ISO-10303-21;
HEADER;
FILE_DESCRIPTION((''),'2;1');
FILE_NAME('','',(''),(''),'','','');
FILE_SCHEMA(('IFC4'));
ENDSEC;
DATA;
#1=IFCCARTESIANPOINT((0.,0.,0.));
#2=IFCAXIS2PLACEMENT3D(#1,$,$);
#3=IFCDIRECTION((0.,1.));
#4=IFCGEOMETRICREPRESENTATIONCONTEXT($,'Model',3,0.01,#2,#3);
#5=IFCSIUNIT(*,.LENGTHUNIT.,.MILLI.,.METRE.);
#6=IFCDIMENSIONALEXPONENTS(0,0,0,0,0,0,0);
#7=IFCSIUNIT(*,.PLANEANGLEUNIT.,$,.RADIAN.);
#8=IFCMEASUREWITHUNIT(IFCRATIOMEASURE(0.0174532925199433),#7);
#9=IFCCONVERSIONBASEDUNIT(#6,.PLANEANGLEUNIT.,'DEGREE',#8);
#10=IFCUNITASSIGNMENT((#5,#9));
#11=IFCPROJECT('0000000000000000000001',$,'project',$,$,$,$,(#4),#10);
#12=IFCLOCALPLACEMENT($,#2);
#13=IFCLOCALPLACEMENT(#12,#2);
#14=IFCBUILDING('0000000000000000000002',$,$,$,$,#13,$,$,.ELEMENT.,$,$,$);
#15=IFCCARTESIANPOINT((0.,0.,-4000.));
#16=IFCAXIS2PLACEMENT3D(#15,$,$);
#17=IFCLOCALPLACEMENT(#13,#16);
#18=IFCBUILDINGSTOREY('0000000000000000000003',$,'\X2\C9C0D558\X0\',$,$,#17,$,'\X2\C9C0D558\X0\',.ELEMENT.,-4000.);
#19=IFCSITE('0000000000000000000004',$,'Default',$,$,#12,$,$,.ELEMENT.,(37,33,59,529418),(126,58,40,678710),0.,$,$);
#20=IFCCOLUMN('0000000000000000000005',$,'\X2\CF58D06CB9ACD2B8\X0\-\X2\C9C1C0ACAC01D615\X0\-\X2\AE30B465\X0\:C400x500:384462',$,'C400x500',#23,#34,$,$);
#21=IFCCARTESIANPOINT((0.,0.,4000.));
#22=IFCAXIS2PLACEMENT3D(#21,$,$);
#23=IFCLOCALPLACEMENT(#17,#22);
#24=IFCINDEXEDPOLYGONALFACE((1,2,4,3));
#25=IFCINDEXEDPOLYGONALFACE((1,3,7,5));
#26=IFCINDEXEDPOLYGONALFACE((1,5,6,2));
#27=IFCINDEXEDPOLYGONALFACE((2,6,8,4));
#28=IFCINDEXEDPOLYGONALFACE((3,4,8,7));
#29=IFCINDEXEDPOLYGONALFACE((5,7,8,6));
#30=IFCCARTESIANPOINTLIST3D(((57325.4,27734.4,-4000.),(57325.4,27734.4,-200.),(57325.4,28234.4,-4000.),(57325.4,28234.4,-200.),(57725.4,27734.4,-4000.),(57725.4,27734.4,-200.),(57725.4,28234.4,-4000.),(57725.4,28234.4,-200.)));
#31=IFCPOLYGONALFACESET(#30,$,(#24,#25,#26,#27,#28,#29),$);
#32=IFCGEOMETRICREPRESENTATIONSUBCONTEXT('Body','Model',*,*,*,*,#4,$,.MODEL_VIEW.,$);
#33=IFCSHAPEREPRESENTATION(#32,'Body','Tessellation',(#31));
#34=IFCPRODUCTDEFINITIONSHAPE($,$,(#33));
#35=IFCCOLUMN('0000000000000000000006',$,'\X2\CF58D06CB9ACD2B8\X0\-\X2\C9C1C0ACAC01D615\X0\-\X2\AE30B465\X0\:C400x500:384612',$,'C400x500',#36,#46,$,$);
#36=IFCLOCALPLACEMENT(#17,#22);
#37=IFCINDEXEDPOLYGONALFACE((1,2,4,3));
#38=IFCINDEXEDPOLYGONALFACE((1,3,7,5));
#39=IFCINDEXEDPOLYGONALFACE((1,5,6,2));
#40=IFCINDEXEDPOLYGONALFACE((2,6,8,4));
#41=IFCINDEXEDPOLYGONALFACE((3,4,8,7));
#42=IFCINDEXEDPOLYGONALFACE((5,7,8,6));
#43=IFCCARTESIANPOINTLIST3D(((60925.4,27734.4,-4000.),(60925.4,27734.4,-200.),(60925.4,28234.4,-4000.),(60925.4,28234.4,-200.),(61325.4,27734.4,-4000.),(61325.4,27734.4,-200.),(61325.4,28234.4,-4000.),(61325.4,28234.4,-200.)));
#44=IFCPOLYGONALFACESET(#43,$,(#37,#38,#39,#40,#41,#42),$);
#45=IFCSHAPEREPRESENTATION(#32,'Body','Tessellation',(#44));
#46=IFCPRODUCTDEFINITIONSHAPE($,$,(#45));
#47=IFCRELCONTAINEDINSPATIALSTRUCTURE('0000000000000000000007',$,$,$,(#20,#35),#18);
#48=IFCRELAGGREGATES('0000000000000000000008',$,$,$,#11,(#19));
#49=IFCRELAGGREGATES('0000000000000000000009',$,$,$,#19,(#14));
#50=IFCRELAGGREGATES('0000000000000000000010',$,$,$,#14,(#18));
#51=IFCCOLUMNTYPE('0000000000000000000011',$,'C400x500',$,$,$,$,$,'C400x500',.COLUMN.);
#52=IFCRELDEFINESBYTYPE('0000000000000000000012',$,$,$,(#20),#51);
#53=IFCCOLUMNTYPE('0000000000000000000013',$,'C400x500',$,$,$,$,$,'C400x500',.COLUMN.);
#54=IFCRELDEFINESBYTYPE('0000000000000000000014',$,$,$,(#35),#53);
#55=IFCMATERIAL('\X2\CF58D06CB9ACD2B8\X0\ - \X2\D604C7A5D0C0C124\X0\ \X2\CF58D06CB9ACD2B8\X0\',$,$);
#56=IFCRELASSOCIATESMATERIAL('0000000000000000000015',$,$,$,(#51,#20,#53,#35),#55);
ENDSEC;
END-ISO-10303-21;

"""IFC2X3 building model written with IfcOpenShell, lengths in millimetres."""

from ifc_helpers import new_model, entity, si_unit, converted_unit, direction, frame, origin, origin_2d_with_axis, place, context, subcontext, project, spatial, rectangle, extrude, source, transform, mapped, material, type_object, type_shapes, element, save


model = new_model("IFC2X3")

# Units and contexts
model_context = context("Model", 3, precision=0.01, world=origin(), true_north=direction((0.0, 1.0)))
body_context = subcontext(model_context, "Body", "Model", "MODEL_VIEW")
ifc_project = project(units=[si_unit("LENGTHUNIT", "METRE", prefix="MILLI"), converted_unit("PLANEANGLEUNIT", "DEGREE", entity("IfcRatioMeasure", 0.0174532925199433), si_unit("PLANEANGLEUNIT", "RADIAN"), dimensions=[0, 0, 0, 0, 0, 0, 0])], contexts=[model_context])

# Site, building, storey
site_placement = place(None, origin())
site = spatial("IfcSite", under=ifc_project, at=site_placement, Name="Default", CompositionType="ELEMENT", RefLatitude=(37, 33, 59, 529418), RefLongitude=(126, 58, 40, 678710), RefElevation=0.0)
building_placement = place(site_placement, origin())
building = spatial("IfcBuilding", under=site, at=building_placement, CompositionType="ELEMENT")
storey_placement = place(building_placement, frame((0.0, 0.0, -4000.0)))
storey = spatial("IfcBuildingStorey", under=building, at=storey_placement, Name="지하", LongName="지하", CompositionType="ELEMENT", Elevation=-4000.0)

# Columns
ifc_material_1 = material(Name="콘크리트 - 현장타설 콘크리트")
column_type_1 = type_object("IfcColumnType", Name="C400x500", ElementType="C400x500", PredefinedType="COLUMN", material=ifc_material_1)
shared_shape_1 = source(origin(), body_context, "Body", "SweptSolid", [
    extrude(rectangle(XDim=500.0, YDim=400.0, at=origin_2d_with_axis()), frame((57525.4, 27984.4, -4000.0), z_axis=(0.0, 0.0, 1.0), x_axis=(0.0, -1.0, 0.0)), (0.0, 0.0, 1.0), 3800.0),
])
type_shapes(column_type_1, [shared_shape_1])
column_1_placement = place(storey_placement, frame((0.0, 0.0, 4000.0)))
element("IfcColumn", 1, at=column_1_placement, inside=storey, type_object=column_type_1, material=ifc_material_1, Name="콘크리트-직사각형-기둥:C400x500:384462", ObjectType="C400x500", context=body_context, shape_type="MappedRepresentation", body=[
    mapped(shared_shape_1, transform((0.0, 0.0, 0.0), scale=1.0)),
])
column_type_2 = type_object("IfcColumnType", Name="C400x500", ElementType="C400x500", PredefinedType="COLUMN", material=ifc_material_1)
shared_shape_2 = source(origin(), body_context, "Body", "SweptSolid", [
    extrude(rectangle(XDim=500.0, YDim=400.0, at=origin_2d_with_axis()), frame((61125.4, 27984.4, -4000.0), z_axis=(0.0, 0.0, 1.0), x_axis=(0.0, -1.0, 0.0)), (0.0, 0.0, 1.0), 3800.0),
])
type_shapes(column_type_2, [shared_shape_2])
column_2_placement = place(storey_placement, frame((0.0, 0.0, 4000.0)))
element("IfcColumn", 2, at=column_2_placement, inside=storey, type_object=column_type_2, material=ifc_material_1, Name="콘크리트-직사각형-기둥:C400x500:384612", ObjectType="C400x500", context=body_context, shape_type="MappedRepresentation", body=[
    mapped(shared_shape_2, transform((0.0, 0.0, 0.0), scale=1.0)),
])

save(model, "model.ifc")
